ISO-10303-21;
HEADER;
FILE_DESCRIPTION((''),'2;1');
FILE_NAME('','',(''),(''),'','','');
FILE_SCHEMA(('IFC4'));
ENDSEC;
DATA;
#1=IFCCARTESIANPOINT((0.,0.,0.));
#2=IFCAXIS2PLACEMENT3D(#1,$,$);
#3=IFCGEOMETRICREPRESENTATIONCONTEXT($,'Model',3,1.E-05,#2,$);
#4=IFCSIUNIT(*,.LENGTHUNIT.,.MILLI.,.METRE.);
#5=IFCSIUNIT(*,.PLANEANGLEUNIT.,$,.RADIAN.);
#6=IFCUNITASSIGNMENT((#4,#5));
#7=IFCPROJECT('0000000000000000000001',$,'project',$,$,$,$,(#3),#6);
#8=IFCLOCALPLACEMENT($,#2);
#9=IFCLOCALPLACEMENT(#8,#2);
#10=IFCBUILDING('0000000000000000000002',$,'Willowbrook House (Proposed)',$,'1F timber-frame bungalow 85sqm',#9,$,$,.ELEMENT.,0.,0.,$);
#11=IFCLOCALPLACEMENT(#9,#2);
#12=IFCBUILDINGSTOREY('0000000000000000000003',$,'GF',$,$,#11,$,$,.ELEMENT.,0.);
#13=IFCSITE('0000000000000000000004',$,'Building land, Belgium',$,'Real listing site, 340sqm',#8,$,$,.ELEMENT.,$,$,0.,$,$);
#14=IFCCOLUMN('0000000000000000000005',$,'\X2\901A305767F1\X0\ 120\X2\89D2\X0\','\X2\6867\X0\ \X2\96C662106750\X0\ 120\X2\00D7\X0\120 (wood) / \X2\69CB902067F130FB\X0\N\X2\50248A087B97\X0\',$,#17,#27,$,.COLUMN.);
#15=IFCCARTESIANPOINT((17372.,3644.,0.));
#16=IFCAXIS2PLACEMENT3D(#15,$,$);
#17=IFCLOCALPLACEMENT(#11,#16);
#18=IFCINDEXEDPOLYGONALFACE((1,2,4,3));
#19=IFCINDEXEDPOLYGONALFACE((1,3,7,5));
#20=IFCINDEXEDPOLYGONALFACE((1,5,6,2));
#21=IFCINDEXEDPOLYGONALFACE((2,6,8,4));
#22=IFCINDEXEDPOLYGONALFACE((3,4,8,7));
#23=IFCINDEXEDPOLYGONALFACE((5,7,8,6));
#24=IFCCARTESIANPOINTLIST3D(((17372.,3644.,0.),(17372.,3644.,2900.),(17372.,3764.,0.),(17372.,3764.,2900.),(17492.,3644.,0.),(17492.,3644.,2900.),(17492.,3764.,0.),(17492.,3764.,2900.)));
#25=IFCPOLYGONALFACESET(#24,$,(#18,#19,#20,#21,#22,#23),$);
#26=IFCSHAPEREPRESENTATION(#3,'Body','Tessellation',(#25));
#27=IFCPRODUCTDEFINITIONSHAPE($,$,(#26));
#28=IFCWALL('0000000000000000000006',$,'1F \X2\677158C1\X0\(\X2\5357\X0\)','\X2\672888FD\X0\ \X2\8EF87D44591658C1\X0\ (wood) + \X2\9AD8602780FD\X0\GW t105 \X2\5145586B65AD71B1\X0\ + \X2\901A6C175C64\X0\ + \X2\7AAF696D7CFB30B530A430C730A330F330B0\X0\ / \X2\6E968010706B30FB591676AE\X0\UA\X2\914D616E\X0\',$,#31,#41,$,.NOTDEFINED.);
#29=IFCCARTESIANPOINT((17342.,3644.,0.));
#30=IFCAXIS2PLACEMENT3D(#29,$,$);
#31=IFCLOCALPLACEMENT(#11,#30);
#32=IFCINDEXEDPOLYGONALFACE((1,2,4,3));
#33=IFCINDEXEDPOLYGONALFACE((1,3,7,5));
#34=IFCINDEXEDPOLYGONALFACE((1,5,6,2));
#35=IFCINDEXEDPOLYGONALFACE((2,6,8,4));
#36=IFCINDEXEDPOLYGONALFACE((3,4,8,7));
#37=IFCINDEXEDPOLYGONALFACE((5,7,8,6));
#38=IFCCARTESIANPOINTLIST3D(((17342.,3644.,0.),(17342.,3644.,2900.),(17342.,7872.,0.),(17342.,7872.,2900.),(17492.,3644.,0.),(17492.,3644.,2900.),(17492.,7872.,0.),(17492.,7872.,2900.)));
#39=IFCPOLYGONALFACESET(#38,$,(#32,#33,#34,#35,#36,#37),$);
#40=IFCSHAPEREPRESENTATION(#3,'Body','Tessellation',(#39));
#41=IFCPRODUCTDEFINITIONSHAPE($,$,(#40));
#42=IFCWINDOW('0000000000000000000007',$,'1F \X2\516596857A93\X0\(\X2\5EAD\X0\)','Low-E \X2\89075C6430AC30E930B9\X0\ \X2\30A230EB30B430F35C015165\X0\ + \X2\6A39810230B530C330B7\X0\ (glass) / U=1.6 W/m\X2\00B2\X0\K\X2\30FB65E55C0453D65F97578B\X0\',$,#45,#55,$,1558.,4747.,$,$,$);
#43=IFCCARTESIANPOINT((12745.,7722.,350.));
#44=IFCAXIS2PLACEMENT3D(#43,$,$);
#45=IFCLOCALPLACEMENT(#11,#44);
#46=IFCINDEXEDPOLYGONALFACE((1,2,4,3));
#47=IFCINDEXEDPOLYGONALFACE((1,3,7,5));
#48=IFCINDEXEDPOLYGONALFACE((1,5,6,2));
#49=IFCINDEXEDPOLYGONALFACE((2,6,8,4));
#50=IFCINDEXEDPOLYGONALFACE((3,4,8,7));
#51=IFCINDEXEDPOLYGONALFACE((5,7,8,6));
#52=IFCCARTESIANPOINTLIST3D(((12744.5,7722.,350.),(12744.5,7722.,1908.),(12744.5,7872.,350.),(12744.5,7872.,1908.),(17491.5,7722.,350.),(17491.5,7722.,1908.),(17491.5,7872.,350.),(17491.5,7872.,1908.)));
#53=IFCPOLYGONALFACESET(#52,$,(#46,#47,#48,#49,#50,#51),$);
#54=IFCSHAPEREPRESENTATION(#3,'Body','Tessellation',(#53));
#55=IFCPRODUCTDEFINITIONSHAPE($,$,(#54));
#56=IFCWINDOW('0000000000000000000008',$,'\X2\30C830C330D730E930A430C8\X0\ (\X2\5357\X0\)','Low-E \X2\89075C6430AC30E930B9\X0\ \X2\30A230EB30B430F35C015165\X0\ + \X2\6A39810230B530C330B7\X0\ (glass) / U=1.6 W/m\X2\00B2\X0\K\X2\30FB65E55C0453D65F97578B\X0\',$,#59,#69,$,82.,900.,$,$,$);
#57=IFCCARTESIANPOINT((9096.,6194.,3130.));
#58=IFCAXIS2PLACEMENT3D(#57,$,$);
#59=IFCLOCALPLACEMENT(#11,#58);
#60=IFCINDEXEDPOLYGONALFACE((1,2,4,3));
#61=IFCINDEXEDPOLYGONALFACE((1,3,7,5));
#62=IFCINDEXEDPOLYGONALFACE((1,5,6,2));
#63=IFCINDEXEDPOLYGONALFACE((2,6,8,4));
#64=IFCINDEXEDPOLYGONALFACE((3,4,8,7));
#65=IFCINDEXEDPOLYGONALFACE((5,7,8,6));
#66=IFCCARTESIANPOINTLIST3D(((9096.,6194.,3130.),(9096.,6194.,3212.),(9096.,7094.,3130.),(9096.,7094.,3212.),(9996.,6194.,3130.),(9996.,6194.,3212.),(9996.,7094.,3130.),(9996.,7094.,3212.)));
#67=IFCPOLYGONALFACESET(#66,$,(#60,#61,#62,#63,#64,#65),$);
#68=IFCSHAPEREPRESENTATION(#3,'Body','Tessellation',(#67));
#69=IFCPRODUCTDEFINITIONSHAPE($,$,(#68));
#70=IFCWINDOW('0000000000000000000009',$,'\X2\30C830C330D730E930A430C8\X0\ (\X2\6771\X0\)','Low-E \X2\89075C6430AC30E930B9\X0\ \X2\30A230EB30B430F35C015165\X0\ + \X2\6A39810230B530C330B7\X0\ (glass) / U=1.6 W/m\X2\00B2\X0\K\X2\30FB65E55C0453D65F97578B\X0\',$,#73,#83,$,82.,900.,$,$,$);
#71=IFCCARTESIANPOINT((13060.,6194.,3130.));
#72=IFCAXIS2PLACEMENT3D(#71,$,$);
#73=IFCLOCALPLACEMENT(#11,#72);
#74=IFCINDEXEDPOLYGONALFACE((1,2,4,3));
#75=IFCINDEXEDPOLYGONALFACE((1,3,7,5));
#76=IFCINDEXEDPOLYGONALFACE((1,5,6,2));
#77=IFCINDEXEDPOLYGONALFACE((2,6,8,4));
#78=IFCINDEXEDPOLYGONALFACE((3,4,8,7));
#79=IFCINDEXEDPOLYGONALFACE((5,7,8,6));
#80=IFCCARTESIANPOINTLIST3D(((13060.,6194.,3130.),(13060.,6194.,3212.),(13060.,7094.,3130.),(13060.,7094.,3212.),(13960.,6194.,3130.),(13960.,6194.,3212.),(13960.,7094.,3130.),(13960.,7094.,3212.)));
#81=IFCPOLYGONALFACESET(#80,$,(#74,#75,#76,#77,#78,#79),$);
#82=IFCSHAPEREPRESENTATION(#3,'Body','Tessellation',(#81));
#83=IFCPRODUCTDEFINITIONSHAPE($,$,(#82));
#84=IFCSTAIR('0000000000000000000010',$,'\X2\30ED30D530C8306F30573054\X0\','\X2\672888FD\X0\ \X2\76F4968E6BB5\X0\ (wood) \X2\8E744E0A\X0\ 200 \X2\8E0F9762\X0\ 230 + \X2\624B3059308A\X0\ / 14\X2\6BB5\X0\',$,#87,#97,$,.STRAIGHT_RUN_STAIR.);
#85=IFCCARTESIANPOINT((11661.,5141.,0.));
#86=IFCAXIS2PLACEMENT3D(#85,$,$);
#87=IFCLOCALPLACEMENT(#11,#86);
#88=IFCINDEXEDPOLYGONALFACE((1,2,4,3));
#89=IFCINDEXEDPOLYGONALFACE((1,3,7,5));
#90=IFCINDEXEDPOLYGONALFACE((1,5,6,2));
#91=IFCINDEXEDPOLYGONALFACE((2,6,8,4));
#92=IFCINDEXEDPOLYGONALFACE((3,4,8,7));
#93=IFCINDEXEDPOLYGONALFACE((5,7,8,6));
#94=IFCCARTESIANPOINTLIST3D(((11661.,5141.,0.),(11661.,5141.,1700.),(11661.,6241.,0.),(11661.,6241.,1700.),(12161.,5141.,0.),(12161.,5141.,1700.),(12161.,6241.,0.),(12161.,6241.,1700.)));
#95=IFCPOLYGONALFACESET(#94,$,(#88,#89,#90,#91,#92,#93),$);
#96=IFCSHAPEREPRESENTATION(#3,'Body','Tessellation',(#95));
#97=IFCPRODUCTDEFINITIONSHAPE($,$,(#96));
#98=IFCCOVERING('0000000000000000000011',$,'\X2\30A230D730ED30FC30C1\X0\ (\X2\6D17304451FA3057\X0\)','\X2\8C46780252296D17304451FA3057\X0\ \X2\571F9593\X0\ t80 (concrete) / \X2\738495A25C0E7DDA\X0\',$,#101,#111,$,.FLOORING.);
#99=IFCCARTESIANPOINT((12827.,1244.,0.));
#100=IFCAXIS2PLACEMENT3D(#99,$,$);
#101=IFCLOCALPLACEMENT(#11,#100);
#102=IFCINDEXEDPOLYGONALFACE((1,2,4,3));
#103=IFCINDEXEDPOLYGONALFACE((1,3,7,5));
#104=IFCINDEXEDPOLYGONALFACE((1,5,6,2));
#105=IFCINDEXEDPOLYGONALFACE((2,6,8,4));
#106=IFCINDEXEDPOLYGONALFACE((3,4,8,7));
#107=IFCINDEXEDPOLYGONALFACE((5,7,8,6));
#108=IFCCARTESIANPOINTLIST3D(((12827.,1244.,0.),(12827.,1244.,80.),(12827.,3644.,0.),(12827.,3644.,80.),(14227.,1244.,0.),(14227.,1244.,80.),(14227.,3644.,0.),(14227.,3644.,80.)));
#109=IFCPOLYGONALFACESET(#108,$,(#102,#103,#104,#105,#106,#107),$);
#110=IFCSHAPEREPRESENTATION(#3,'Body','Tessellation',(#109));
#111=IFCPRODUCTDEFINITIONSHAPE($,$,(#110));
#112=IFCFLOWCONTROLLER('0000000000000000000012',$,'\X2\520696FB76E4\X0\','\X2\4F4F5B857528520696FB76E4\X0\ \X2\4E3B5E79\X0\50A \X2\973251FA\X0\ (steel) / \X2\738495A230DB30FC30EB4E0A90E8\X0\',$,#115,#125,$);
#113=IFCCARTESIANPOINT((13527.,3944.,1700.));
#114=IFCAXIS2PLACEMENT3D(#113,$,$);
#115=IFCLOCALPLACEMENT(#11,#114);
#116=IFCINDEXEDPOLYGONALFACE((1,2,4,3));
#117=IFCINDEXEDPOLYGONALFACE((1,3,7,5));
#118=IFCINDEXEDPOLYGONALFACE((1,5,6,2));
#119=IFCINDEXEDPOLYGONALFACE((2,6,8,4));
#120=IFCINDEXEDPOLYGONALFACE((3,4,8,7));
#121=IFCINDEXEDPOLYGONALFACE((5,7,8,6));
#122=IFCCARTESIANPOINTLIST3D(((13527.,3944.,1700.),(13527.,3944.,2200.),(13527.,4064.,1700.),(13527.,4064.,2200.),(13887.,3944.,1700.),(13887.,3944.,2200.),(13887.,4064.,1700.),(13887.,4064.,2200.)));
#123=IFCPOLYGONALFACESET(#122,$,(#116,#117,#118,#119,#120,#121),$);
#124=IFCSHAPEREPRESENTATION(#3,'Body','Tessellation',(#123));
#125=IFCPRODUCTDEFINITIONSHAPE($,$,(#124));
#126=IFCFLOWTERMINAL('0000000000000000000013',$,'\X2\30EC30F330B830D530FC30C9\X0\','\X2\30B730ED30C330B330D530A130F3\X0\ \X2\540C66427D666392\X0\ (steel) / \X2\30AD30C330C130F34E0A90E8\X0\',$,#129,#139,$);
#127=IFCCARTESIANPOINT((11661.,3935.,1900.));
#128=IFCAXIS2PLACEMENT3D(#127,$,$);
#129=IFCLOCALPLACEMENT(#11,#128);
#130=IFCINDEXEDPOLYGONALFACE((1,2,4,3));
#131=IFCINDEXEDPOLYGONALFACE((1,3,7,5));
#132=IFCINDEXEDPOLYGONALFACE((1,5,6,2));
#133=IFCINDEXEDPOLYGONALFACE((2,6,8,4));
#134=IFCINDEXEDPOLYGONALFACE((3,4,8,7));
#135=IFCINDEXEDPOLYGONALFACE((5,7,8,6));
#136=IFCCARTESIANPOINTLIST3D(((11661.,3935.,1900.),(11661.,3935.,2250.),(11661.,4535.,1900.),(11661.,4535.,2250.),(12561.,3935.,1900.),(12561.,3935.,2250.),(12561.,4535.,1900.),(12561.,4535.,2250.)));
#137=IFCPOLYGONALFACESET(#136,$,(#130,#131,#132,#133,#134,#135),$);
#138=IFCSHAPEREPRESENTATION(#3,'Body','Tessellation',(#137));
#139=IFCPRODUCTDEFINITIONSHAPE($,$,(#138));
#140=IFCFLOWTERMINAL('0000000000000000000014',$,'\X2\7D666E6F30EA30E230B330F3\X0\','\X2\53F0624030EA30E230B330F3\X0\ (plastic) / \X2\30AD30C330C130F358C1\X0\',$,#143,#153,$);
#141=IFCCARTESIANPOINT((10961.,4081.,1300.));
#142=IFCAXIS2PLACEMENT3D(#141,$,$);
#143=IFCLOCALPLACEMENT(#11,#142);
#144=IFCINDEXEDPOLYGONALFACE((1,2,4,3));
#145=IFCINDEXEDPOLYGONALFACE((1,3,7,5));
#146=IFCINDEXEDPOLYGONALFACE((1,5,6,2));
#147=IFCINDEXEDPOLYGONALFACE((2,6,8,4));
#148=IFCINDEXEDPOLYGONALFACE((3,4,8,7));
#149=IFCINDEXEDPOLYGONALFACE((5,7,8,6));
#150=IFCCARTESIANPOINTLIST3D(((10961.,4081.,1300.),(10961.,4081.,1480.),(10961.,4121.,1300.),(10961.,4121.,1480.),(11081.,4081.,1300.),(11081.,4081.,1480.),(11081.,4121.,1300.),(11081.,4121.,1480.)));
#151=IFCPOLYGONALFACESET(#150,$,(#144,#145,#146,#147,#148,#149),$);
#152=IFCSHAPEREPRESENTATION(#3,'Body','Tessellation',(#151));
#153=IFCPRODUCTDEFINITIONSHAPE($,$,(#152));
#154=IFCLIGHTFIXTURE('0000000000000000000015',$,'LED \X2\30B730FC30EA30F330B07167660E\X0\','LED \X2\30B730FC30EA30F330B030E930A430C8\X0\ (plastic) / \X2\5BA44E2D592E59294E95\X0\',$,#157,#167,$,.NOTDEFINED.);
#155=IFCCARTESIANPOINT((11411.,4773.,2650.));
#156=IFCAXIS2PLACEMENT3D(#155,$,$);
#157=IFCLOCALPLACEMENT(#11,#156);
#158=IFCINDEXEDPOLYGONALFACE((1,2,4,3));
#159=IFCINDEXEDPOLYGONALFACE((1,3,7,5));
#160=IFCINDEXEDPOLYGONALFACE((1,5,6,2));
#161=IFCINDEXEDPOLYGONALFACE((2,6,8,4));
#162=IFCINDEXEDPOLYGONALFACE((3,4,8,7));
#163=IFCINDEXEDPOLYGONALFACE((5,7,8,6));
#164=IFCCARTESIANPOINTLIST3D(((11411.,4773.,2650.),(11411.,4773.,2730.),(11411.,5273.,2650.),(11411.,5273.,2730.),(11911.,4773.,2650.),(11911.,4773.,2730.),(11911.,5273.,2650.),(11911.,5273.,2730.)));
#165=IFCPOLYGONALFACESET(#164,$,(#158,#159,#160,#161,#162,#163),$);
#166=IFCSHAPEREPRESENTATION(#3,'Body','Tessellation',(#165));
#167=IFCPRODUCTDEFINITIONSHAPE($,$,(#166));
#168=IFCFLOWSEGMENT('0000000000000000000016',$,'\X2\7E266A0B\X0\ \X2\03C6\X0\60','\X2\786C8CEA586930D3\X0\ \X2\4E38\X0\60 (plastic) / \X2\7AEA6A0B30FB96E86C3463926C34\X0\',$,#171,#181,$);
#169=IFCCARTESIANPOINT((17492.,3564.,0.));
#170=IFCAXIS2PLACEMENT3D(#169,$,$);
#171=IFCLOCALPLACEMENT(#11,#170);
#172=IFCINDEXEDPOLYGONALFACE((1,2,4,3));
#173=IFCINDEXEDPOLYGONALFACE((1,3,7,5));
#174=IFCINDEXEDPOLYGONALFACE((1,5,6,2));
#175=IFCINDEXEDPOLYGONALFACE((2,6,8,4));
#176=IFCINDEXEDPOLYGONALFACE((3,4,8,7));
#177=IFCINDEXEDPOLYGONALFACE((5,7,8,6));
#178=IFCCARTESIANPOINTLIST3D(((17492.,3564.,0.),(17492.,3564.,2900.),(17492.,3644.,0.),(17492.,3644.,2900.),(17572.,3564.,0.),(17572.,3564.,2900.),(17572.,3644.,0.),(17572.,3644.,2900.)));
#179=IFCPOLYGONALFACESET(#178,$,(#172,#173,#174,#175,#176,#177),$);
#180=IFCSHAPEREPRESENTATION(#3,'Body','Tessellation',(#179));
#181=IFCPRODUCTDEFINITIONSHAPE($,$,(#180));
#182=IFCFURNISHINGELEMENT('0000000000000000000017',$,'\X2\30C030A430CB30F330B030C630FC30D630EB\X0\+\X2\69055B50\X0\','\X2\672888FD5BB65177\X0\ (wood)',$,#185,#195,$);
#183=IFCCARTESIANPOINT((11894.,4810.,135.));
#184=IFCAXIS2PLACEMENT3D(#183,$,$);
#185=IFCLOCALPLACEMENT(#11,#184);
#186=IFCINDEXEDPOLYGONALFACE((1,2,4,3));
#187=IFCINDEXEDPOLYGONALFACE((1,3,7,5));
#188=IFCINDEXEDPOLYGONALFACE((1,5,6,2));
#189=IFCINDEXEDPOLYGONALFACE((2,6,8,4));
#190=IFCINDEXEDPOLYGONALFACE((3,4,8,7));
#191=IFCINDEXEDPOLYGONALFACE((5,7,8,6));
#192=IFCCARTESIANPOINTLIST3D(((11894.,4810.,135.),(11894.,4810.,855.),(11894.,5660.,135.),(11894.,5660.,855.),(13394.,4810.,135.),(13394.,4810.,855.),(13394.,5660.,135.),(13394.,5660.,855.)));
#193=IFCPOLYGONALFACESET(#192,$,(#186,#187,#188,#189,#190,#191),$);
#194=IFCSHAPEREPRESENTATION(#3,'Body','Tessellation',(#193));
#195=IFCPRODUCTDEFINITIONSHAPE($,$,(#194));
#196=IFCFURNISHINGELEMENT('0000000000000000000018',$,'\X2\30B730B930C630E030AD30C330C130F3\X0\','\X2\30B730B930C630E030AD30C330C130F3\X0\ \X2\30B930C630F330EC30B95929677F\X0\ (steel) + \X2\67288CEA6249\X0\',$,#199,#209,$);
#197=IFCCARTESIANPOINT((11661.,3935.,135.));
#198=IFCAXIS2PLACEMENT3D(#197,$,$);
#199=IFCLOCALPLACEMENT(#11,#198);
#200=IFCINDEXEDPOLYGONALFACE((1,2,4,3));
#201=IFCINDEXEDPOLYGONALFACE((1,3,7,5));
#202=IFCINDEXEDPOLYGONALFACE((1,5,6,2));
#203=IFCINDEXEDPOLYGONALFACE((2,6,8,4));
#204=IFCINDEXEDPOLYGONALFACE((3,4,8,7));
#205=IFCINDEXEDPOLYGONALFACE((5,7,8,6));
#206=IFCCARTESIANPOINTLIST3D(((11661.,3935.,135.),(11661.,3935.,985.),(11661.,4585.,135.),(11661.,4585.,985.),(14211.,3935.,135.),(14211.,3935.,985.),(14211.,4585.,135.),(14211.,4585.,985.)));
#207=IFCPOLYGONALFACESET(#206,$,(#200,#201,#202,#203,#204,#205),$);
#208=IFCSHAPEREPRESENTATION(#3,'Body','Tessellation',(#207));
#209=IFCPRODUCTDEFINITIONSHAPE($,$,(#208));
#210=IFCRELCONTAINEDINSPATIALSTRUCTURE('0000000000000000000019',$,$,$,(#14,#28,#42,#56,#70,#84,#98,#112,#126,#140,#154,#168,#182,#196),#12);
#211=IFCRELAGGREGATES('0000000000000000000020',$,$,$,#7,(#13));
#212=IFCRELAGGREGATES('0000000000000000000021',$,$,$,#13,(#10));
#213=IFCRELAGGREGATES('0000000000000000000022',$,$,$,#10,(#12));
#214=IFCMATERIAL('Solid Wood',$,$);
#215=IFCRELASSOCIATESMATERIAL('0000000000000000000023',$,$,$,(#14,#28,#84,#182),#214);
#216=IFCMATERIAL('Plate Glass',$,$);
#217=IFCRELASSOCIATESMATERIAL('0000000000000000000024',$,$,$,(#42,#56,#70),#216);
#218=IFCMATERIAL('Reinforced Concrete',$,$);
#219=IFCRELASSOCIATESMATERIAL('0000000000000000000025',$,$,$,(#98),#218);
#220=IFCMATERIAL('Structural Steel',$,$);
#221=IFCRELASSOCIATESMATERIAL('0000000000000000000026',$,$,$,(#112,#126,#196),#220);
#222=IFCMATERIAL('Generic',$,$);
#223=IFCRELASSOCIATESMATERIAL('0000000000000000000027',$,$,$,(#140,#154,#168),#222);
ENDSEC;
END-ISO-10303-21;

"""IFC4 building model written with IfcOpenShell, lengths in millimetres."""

from ifc_helpers import new_model, si_unit, frame, frame_2d, origin, place, context, project, spatial, rectangle, extrude, material, element, fill, save


model = new_model("IFC4")

# Units and contexts
model_context = context("Model", 3, precision=1e-05, world=origin())
ifc_project = project(units=[si_unit("LENGTHUNIT", "METRE", prefix="MILLI"), si_unit("PLANEANGLEUNIT", "RADIAN")], contexts=[model_context])

# Site, building, storey
site_placement = place(None, origin())
site = spatial("IfcSite", under=ifc_project, at=site_placement, Name="Building land, Belgium", ObjectType="Real listing site, 340sqm", CompositionType="ELEMENT", RefElevation=0.0)
building_placement = place(site_placement, origin())
building = spatial("IfcBuilding", under=site, at=building_placement, Name="Willowbrook House (Proposed)", ObjectType="1F timber-frame bungalow 85sqm", CompositionType="ELEMENT", ElevationOfRefHeight=0.0, ElevationOfTerrain=0.0)
storey_placement = place(building_placement, origin())
storey = spatial("IfcBuildingStorey", under=building, at=storey_placement, Name="GF", CompositionType="ELEMENT", Elevation=0.0)

# Column
ifc_material_1 = material(Name="Solid Wood")
column_1_placement = place(storey_placement, frame((17372.0, 3644.0, 0.0)))
element("IfcColumn", 1, at=column_1_placement, inside=storey, material=ifc_material_1, Name="通し柱 120角", Description="桧 集成材 120×120 (wood) / 構造柱・N値計算", PredefinedType="COLUMN", context=model_context, shape_type="SweptSolid", body=[
    extrude(rectangle(XDim=120.0, YDim=120.0, at=frame_2d((60.0, 60.0))), frame((17372.0, 3644.0, 0.0)), (0.0, 0.0, 1.0), 2900.0),
])

# Wall, opening, window
wall_1_placement = place(storey_placement, frame((17342.0, 3644.0, 0.0)))
wall_1 = element("IfcWall", 2, at=wall_1_placement, inside=storey, material=ifc_material_1, Name="1F 東壁(南)", Description="木製 軸組外壁 (wood) + 高性能GW t105 充填断熱 + 通気層 + 窯業系サイディング / 準耐火・外皮UA配慮", PredefinedType="NOTDEFINED", context=model_context, shape_type="SweptSolid", body=[
    extrude(rectangle(XDim=150.0, YDim=4228.0, at=frame_2d((75.0, 2114.0))), frame((17342.0, 3644.0, 0.0)), (0.0, 0.0, 1.0), 2900.0),
])
opening_1_placement = place(storey_placement, frame((12745.0, 7722.0, 350.0)))
opening_1 = element("IfcOpeningElement", 3, at=opening_1_placement, cuts=wall_1, PredefinedType="NOTDEFINED", context=model_context, shape_type="SweptSolid", body=[
    extrude(rectangle(XDim=4747.0, YDim=150.0, at=frame_2d((2373.0, 75.0))), frame((12745.0, 7722.0, 350.0)), (0.0, 0.0, 1.0), 1558.0),
])
ifc_material_2 = material(Name="Plate Glass")
window_1_placement = place(storey_placement, frame((12745.0, 7722.0, 350.0)))
window_1 = element("IfcWindow", 4, at=window_1_placement, inside=storey, material=ifc_material_2, Name="1F 入隅窓(庭)", Description="Low-E 複層ガラス アルゴン封入 + 樹脂サッシ (glass) / U=1.6 W/m²K・日射取得型", OverallHeight=1558.0, OverallWidth=4747.0, context=model_context, shape_type="SweptSolid", body=[
    extrude(rectangle(XDim=4747.0, YDim=150.0, at=frame_2d((2373.0, 75.0))), frame((12745.0, 7722.0, 350.0)), (0.0, 0.0, 1.0), 1558.0),
])
fill(opening_1, window_1)

# Windows
window_2_placement = place(storey_placement, frame((9096.0, 6194.0, 3130.0)))
element("IfcWindow", 5, at=window_2_placement, inside=storey, material=ifc_material_2, Name="トップライト (南)", Description="Low-E 複層ガラス アルゴン封入 + 樹脂サッシ (glass) / U=1.6 W/m²K・日射取得型", OverallHeight=82.0, OverallWidth=900.0, context=model_context, shape_type="SweptSolid", body=[
    extrude(rectangle(XDim=900.0, YDim=900.0, at=frame_2d((450.0, 450.0))), frame((9096.0, 6194.0, 3130.0)), (0.0, 0.0, 1.0), 82.0),
])
window_3_placement = place(storey_placement, frame((13060.0, 6194.0, 3130.0)))
element("IfcWindow", 6, at=window_3_placement, inside=storey, material=ifc_material_2, Name="トップライト (東)", Description="Low-E 複層ガラス アルゴン封入 + 樹脂サッシ (glass) / U=1.6 W/m²K・日射取得型", OverallHeight=82.0, OverallWidth=900.0, context=model_context, shape_type="SweptSolid", body=[
    extrude(rectangle(XDim=900.0, YDim=900.0, at=frame_2d((450.0, 450.0))), frame((13060.0, 6194.0, 3130.0)), (0.0, 0.0, 1.0), 82.0),
])

# Stair
stair_placement = place(storey_placement, frame((11661.0, 5141.0, 0.0)))
element("IfcStair", 7, at=stair_placement, inside=storey, material=ifc_material_1, Name="ロフトはしご", Description="木製 直階段 (wood) 蹴上 200 踏面 230 + 手すり / 14段", PredefinedType="STRAIGHT_RUN_STAIR", context=model_context, shape_type="SweptSolid", body=[
    extrude(rectangle(XDim=500.0, YDim=1100.0, at=frame_2d((250.0, 550.0))), frame((11661.0, 5141.0, 0.0)), (0.0, 0.0, 1.0), 1700.0),
])

# Covering
ifc_material_3 = material(Name="Reinforced Concrete")
covering_placement = place(storey_placement, frame((12827.0, 1244.0, 0.0)))
element("IfcCovering", 8, at=covering_placement, inside=storey, material=ifc_material_3, Name="アプローチ (洗い出し)", Description="豆砂利洗い出し 土間 t80 (concrete) / 玄関導線", PredefinedType="FLOORING", context=model_context, shape_type="SweptSolid", body=[
    extrude(rectangle(XDim=1400.0, YDim=2400.0, at=frame_2d((700.0, 1200.0))), frame((12827.0, 1244.0, 0.0)), (0.0, 0.0, 1.0), 80.0),
])

# Flow controller
ifc_material_4 = material(Name="Structural Steel")
flow_controller_placement = place(storey_placement, frame((13527.0, 3944.0, 1700.0)))
element("IfcFlowController", 9, at=flow_controller_placement, inside=storey, material=ifc_material_4, Name="分電盤", Description="住宅用分電盤 主幹50A 露出 (steel) / 玄関ホール上部", context=model_context, shape_type="SweptSolid", body=[
    extrude(rectangle(XDim=360.0, YDim=120.0, at=frame_2d((180.0, 60.0))), frame((13527.0, 3944.0, 1700.0)), (0.0, 0.0, 1.0), 500.0),
])

# Flow terminals
flow_terminal_1_placement = place(storey_placement, frame((11661.0, 3935.0, 1900.0)))
element("IfcFlowTerminal", 10, at=flow_terminal_1_placement, inside=storey, material=ifc_material_4, Name="レンジフード", Description="シロッコファン 同時給排 (steel) / キッチン上部", context=model_context, shape_type="SweptSolid", body=[
    extrude(rectangle(XDim=900.0, YDim=600.0, at=frame_2d((450.0, 300.0))), frame((11661.0, 3935.0, 1900.0)), (0.0, 0.0, 1.0), 350.0),
])
ifc_material_5 = material(Name="Generic")
flow_terminal_2_placement = place(storey_placement, frame((10961.0, 4081.0, 1300.0)))
element("IfcFlowTerminal", 11, at=flow_terminal_2_placement, inside=storey, material=ifc_material_5, Name="給湯リモコン", Description="台所リモコン (plastic) / キッチン壁", context=model_context, shape_type="SweptSolid", body=[
    extrude(rectangle(XDim=120.0, YDim=40.0, at=frame_2d((60.0, 20.0))), frame((10961.0, 4081.0, 1300.0)), (0.0, 0.0, 1.0), 180.0),
])

# Light fixture
light_fixture_placement = place(storey_placement, frame((11411.0, 4773.0, 2650.0)))
element("IfcLightFixture", 12, at=light_fixture_placement, inside=storey, material=ifc_material_5, Name="LED シーリング照明", Description="LED シーリングライト (plastic) / 室中央天井", PredefinedType="NOTDEFINED", context=model_context, shape_type="SweptSolid", body=[
    extrude(rectangle(XDim=500.0, YDim=500.0, at=frame_2d((250.0, 250.0))), frame((11411.0, 4773.0, 2650.0)), (0.0, 0.0, 1.0), 80.0),
])

# Flow segment
flow_segment_placement = place(storey_placement, frame((17492.0, 3564.0, 0.0)))
element("IfcFlowSegment", 13, at=flow_segment_placement, inside=storey, material=ifc_material_5, Name="縦樋 φ60", Description="硬質塩ビ 丸60 (plastic) / 竪樋・雨水排水", context=model_context, shape_type="SweptSolid", body=[
    extrude(rectangle(XDim=80.0, YDim=80.0, at=frame_2d((40.0, 40.0))), frame((17492.0, 3564.0, 0.0)), (0.0, 0.0, 1.0), 2900.0),
])

# Furnishing elements
furnishing_1_placement = place(storey_placement, frame((11894.0, 4810.0, 135.0)))
element("IfcFurnishingElement", 14, at=furnishing_1_placement, inside=storey, material=ifc_material_1, Name="ダイニングテーブル+椅子", Description="木製家具 (wood)", context=model_context, shape_type="SweptSolid", body=[
    extrude(rectangle(XDim=1500.0, YDim=850.0, at=frame_2d((750.0, 425.0))), frame((11894.0, 4810.0, 135.0)), (0.0, 0.0, 1.0), 720.0),
])
furnishing_2_placement = place(storey_placement, frame((11661.0, 3935.0, 135.0)))
element("IfcFurnishingElement", 15, at=furnishing_2_placement, inside=storey, material=ifc_material_4, Name="システムキッチン", Description="システムキッチン ステンレス天板 (steel) + 木質扉", context=model_context, shape_type="SweptSolid", body=[
    extrude(rectangle(XDim=2550.0, YDim=650.0, at=frame_2d((1275.0, 325.0))), frame((11661.0, 3935.0, 135.0)), (0.0, 0.0, 1.0), 850.0),
])

save(model, "model.ifc")
